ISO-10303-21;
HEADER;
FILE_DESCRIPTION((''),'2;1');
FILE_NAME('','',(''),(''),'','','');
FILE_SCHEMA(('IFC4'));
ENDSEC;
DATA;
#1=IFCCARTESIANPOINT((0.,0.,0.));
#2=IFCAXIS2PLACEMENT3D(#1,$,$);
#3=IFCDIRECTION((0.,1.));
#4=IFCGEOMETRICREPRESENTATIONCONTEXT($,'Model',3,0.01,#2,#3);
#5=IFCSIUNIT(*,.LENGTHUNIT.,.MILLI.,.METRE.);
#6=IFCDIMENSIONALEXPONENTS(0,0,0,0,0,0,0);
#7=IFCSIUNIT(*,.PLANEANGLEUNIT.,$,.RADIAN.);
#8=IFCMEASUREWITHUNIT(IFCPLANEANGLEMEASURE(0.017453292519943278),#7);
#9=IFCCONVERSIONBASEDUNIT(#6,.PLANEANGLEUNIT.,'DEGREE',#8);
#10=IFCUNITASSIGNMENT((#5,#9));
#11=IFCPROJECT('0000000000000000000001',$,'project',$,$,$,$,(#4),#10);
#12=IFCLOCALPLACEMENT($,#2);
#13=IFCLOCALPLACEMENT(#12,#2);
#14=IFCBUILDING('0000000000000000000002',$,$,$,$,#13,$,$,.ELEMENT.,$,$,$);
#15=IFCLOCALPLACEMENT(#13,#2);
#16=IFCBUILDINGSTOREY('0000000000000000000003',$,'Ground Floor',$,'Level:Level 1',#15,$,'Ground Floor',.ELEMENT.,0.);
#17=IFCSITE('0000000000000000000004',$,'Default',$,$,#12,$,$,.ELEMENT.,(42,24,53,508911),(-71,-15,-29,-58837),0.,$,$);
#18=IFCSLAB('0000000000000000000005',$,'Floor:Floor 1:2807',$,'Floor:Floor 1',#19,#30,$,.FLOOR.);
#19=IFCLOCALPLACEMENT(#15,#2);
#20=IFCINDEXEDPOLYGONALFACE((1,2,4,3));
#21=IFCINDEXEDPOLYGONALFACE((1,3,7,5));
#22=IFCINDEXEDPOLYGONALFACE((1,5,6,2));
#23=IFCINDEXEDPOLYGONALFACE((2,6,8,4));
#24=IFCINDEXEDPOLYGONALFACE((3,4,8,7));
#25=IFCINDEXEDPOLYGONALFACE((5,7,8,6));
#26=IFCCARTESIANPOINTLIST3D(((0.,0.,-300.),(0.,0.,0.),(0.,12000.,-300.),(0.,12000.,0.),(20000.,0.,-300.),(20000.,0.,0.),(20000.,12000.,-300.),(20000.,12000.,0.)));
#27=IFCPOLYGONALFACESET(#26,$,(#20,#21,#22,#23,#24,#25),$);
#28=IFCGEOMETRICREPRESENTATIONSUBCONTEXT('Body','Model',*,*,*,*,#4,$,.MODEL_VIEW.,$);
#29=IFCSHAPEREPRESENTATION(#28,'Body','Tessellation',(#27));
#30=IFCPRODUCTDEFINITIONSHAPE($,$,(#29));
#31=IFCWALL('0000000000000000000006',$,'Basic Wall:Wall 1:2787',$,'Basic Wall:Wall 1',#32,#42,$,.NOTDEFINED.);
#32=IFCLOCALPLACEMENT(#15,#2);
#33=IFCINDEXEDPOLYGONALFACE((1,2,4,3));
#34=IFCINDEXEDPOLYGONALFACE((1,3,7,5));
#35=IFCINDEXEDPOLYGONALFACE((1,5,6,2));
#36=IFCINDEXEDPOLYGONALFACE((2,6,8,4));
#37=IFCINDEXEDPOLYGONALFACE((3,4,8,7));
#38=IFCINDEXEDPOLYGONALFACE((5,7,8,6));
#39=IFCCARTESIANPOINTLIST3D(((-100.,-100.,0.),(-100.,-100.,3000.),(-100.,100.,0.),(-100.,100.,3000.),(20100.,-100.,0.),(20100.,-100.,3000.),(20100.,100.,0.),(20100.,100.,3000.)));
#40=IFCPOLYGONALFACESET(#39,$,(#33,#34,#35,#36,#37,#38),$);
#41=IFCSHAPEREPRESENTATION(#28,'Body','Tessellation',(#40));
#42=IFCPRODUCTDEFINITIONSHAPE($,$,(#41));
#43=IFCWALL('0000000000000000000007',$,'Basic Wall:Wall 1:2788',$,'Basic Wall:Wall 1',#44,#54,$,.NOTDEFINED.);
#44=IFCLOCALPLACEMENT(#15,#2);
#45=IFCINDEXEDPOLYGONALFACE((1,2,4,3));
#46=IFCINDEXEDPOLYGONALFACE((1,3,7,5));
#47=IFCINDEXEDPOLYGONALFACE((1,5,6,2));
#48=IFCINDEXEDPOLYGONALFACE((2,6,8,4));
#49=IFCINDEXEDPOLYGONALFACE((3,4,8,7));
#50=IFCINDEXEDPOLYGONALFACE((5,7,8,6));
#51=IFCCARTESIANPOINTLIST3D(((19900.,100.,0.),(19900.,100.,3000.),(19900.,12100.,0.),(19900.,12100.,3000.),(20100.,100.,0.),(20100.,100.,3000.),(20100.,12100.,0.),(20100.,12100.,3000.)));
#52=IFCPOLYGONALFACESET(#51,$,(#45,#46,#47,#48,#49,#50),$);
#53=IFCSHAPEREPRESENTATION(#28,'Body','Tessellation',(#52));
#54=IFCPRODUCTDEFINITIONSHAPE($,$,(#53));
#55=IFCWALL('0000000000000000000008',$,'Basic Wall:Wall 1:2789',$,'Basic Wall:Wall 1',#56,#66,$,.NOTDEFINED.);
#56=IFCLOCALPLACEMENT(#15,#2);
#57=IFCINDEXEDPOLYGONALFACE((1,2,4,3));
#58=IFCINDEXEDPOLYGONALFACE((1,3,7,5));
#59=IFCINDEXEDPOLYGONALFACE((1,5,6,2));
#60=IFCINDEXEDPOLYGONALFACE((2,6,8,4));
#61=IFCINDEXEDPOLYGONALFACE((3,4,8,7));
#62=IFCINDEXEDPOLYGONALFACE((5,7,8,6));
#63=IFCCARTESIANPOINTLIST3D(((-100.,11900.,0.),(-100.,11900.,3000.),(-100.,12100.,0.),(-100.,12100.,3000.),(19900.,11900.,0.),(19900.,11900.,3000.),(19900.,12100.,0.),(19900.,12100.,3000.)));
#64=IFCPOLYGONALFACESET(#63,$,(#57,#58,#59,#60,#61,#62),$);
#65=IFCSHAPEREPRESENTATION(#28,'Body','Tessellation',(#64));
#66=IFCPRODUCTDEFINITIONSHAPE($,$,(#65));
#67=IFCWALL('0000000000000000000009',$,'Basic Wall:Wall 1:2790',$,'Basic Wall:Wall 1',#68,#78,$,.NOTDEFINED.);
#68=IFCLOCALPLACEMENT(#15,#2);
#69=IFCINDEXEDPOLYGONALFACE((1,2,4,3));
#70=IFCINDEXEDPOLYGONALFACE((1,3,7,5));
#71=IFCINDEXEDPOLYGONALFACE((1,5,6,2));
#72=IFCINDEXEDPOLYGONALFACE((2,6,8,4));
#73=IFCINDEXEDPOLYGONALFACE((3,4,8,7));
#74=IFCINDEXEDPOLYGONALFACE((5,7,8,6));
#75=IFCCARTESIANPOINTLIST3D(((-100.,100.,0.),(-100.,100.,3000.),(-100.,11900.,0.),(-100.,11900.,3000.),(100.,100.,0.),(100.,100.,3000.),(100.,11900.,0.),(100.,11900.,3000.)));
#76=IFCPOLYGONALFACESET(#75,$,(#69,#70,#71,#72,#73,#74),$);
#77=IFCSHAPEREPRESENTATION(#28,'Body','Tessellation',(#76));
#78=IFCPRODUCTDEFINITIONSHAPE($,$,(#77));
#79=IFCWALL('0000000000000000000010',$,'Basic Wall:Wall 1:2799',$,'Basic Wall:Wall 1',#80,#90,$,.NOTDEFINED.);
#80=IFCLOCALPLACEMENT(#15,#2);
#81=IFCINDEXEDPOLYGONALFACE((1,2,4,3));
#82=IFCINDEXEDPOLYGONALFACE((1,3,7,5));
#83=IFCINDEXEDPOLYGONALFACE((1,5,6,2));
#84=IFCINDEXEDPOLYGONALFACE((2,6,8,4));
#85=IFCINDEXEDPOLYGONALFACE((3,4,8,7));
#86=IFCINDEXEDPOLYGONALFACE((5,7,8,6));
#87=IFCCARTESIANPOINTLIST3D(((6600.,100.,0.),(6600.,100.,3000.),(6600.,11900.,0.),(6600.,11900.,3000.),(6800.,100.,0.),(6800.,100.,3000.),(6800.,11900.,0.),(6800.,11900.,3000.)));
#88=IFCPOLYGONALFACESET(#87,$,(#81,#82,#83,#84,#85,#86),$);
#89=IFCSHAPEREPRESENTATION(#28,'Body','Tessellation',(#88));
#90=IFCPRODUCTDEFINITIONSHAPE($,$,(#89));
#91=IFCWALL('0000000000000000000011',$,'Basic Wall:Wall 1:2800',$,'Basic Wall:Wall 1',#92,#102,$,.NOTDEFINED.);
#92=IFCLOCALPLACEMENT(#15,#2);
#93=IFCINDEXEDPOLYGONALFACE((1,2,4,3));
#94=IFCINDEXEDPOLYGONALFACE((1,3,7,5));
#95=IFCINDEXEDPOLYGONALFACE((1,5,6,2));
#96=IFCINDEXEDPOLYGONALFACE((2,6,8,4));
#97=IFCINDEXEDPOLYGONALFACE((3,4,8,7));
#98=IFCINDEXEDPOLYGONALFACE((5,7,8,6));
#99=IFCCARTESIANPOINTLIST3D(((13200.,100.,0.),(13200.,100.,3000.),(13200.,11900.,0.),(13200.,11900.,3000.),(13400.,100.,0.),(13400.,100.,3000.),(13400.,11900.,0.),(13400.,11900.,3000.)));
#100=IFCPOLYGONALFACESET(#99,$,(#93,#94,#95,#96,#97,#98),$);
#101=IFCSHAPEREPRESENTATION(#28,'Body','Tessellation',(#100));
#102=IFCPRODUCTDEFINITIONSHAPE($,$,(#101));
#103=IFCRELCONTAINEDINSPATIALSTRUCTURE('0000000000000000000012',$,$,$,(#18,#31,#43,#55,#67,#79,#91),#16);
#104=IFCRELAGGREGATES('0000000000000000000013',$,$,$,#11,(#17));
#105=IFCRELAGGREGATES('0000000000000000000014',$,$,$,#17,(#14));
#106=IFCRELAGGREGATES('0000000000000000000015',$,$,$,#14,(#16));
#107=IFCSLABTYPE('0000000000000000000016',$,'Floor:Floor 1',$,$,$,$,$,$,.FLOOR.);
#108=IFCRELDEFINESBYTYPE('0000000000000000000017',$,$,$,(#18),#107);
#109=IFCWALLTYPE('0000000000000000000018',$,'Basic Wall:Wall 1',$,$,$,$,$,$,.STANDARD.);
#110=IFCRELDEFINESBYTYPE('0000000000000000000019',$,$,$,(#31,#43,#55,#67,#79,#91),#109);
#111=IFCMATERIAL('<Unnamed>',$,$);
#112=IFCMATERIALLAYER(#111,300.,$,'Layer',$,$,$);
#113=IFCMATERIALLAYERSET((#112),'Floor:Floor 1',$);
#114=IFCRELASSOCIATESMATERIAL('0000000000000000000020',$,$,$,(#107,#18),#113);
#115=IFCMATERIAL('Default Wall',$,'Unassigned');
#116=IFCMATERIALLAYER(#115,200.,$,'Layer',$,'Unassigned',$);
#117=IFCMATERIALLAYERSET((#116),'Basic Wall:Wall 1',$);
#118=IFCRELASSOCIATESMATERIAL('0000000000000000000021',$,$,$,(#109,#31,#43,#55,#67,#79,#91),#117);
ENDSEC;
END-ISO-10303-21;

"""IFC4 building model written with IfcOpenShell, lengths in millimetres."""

from ifc_helpers import new_model, entity, si_unit, converted_unit, direction, frame, frame_2d, origin, origin_2d_with_axis, place, context, subcontext, project, spatial, rectangle, extrude, material, layer, layer_set, layer_usage, type_object, element, save


model = new_model("IFC4")

# Units and contexts
model_context = context("Model", 3, precision=0.01, world=origin(), true_north=direction((0.0, 1.0)))
body_context = subcontext(model_context, "Body", "Model", "MODEL_VIEW")
ifc_project = project(units=[si_unit("LENGTHUNIT", "METRE", prefix="MILLI"), converted_unit("PLANEANGLEUNIT", "DEGREE", entity("IfcPlaneAngleMeasure", 0.017453292519943278), si_unit("PLANEANGLEUNIT", "RADIAN"), dimensions=[0, 0, 0, 0, 0, 0, 0])], contexts=[model_context])

# Site, building, storey
site_placement = place(None, origin())
site = spatial("IfcSite", under=ifc_project, at=site_placement, Name="Default", CompositionType="ELEMENT", RefLatitude=(42, 24, 53, 508911), RefLongitude=(-71, -15, -29, -58837), RefElevation=0.0)
building_placement = place(site_placement, origin())
building = spatial("IfcBuilding", under=site, at=building_placement, CompositionType="ELEMENT")
storey_placement = place(building_placement, origin())
storey = spatial("IfcBuildingStorey", under=building, at=storey_placement, Name="Ground Floor", ObjectType="Level:Level 1", LongName="Ground Floor", CompositionType="ELEMENT", Elevation=0.0)

# Shared definitions
ifc_material_1 = material(Name="Default Wall", Category="Unassigned")

# Slab
ifc_material_2 = material(Name="<Unnamed>")
ifc_layer_1 = layer(ifc_material_2, 300.0, Name="Layer")
ifc_layer_set_1 = layer_set([ifc_layer_1], Name="Floor:Floor 1")
ifc_layer_usage_1 = layer_usage(ifc_layer_set_1, "AXIS3", "POSITIVE", 0.0)
slab_type = type_object("IfcSlabType", Name="Floor:Floor 1", PredefinedType="FLOOR", material=ifc_layer_set_1)
slab_placement = place(storey_placement, origin())
element("IfcSlab", 1, at=slab_placement, inside=storey, type_object=slab_type, material=ifc_layer_usage_1, Name="Floor:Floor 1:2807", ObjectType="Floor:Floor 1", PredefinedType="FLOOR", context=body_context, shape_type="SweptSolid", body=[
    extrude(rectangle(XDim=12000.0, YDim=20000.0, at=origin_2d_with_axis()), frame((10000.0, 6000.0, 0.0), z_axis=(0.0, 0.0, -1.0), x_axis=(0.0, 1.0, 0.0)), (0.0, 0.0, 1.0), 300.0),
])

# Walls
ifc_layer_2 = layer(ifc_material_1, 200.0, Name="Layer", Category="Unassigned")
ifc_layer_set_2 = layer_set([ifc_layer_2], Name="Basic Wall:Wall 1")
ifc_layer_usage_2 = layer_usage(ifc_layer_set_2, "AXIS2", "NEGATIVE", 100.0)
wall_type = type_object("IfcWallType", Name="Basic Wall:Wall 1", PredefinedType="STANDARD", material=ifc_layer_set_2)
wall_1_placement = place(storey_placement, frame((-100.0, 0.0, 0.0)))
element("IfcWall", 2, at=wall_1_placement, inside=storey, type_object=wall_type, material=ifc_layer_usage_2, Name="Basic Wall:Wall 1:2787", ObjectType="Basic Wall:Wall 1", PredefinedType="NOTDEFINED", context=body_context, shape_type="SweptSolid", body=[
    extrude(rectangle(XDim=20200.0, YDim=200.0, at=frame_2d((10100.0, 0.0), x_axis=(-1.0, 0.0))), origin(), (0.0, 0.0, 1.0), 3000.0),
])
ifc_layer_usage_3 = layer_usage(ifc_layer_set_2, "AXIS2", "NEGATIVE", 100.0)
wall_2_placement = place(storey_placement, frame((20000.0, 100.0, 0.0), z_axis=(0.0, 0.0, 1.0), x_axis=(0.0, 1.0, 0.0)))
element("IfcWall", 3, at=wall_2_placement, inside=storey, type_object=wall_type, material=ifc_layer_usage_3, Name="Basic Wall:Wall 1:2788", ObjectType="Basic Wall:Wall 1", PredefinedType="NOTDEFINED", context=body_context, shape_type="SweptSolid", body=[
    extrude(rectangle(XDim=12000.0, YDim=200.0, at=frame_2d((6000.0, 0.0), x_axis=(-1.0, 0.0))), origin(), (0.0, 0.0, 1.0), 3000.0),
])
ifc_layer_usage_4 = layer_usage(ifc_layer_set_2, "AXIS2", "NEGATIVE", 100.0)
wall_3_placement = place(storey_placement, frame((19900.0, 12000.0, 0.0), z_axis=(0.0, 0.0, 1.0), x_axis=(-1.0, 0.0, 0.0)))
element("IfcWall", 4, at=wall_3_placement, inside=storey, type_object=wall_type, material=ifc_layer_usage_4, Name="Basic Wall:Wall 1:2789", ObjectType="Basic Wall:Wall 1", PredefinedType="NOTDEFINED", context=body_context, shape_type="SweptSolid", body=[
    extrude(rectangle(XDim=20000.0, YDim=200.0, at=frame_2d((10000.0, 0.0), x_axis=(-1.0, 0.0))), origin(), (0.0, 0.0, 1.0), 3000.0),
])
ifc_layer_usage_5 = layer_usage(ifc_layer_set_2, "AXIS2", "NEGATIVE", 100.0)
wall_4_placement = place(storey_placement, frame((0.0, 11900.0, 0.0), z_axis=(0.0, 0.0, 1.0), x_axis=(0.0, -1.0, 0.0)))
element("IfcWall", 5, at=wall_4_placement, inside=storey, type_object=wall_type, material=ifc_layer_usage_5, Name="Basic Wall:Wall 1:2790", ObjectType="Basic Wall:Wall 1", PredefinedType="NOTDEFINED", context=body_context, shape_type="SweptSolid", body=[
    extrude(rectangle(XDim=11800.0, YDim=200.0, at=frame_2d((5900.0, 0.0), x_axis=(-1.0, 0.0))), origin(), (0.0, 0.0, 1.0), 3000.0),
])
ifc_layer_usage_6 = layer_usage(ifc_layer_set_2, "AXIS2", "NEGATIVE", 100.0)
wall_5_placement = place(storey_placement, frame((6700.0, 100.0, 0.0), z_axis=(0.0, 0.0, 1.0), x_axis=(0.0, 1.0, 0.0)))
element("IfcWall", 6, at=wall_5_placement, inside=storey, type_object=wall_type, material=ifc_layer_usage_6, Name="Basic Wall:Wall 1:2799", ObjectType="Basic Wall:Wall 1", PredefinedType="NOTDEFINED", context=body_context, shape_type="SweptSolid", body=[
    extrude(rectangle(XDim=11800.0, YDim=200.0, at=frame_2d((5900.0, 0.0), x_axis=(-1.0, 0.0))), origin(), (0.0, 0.0, 1.0), 3000.0),
])
ifc_layer_usage_7 = layer_usage(ifc_layer_set_2, "AXIS2", "NEGATIVE", 100.0)
wall_6_placement = place(storey_placement, frame((13300.0, 100.0, 0.0), z_axis=(0.0, 0.0, 1.0), x_axis=(0.0, 1.0, 0.0)))
element("IfcWall", 7, at=wall_6_placement, inside=storey, type_object=wall_type, material=ifc_layer_usage_7, Name="Basic Wall:Wall 1:2800", ObjectType="Basic Wall:Wall 1", PredefinedType="NOTDEFINED", context=body_context, shape_type="SweptSolid", body=[
    extrude(rectangle(XDim=11800.0, YDim=200.0, at=frame_2d((5900.0, 0.0), x_axis=(-1.0, 0.0))), origin(), (0.0, 0.0, 1.0), 3000.0),
])

save(model, "model.ifc")
